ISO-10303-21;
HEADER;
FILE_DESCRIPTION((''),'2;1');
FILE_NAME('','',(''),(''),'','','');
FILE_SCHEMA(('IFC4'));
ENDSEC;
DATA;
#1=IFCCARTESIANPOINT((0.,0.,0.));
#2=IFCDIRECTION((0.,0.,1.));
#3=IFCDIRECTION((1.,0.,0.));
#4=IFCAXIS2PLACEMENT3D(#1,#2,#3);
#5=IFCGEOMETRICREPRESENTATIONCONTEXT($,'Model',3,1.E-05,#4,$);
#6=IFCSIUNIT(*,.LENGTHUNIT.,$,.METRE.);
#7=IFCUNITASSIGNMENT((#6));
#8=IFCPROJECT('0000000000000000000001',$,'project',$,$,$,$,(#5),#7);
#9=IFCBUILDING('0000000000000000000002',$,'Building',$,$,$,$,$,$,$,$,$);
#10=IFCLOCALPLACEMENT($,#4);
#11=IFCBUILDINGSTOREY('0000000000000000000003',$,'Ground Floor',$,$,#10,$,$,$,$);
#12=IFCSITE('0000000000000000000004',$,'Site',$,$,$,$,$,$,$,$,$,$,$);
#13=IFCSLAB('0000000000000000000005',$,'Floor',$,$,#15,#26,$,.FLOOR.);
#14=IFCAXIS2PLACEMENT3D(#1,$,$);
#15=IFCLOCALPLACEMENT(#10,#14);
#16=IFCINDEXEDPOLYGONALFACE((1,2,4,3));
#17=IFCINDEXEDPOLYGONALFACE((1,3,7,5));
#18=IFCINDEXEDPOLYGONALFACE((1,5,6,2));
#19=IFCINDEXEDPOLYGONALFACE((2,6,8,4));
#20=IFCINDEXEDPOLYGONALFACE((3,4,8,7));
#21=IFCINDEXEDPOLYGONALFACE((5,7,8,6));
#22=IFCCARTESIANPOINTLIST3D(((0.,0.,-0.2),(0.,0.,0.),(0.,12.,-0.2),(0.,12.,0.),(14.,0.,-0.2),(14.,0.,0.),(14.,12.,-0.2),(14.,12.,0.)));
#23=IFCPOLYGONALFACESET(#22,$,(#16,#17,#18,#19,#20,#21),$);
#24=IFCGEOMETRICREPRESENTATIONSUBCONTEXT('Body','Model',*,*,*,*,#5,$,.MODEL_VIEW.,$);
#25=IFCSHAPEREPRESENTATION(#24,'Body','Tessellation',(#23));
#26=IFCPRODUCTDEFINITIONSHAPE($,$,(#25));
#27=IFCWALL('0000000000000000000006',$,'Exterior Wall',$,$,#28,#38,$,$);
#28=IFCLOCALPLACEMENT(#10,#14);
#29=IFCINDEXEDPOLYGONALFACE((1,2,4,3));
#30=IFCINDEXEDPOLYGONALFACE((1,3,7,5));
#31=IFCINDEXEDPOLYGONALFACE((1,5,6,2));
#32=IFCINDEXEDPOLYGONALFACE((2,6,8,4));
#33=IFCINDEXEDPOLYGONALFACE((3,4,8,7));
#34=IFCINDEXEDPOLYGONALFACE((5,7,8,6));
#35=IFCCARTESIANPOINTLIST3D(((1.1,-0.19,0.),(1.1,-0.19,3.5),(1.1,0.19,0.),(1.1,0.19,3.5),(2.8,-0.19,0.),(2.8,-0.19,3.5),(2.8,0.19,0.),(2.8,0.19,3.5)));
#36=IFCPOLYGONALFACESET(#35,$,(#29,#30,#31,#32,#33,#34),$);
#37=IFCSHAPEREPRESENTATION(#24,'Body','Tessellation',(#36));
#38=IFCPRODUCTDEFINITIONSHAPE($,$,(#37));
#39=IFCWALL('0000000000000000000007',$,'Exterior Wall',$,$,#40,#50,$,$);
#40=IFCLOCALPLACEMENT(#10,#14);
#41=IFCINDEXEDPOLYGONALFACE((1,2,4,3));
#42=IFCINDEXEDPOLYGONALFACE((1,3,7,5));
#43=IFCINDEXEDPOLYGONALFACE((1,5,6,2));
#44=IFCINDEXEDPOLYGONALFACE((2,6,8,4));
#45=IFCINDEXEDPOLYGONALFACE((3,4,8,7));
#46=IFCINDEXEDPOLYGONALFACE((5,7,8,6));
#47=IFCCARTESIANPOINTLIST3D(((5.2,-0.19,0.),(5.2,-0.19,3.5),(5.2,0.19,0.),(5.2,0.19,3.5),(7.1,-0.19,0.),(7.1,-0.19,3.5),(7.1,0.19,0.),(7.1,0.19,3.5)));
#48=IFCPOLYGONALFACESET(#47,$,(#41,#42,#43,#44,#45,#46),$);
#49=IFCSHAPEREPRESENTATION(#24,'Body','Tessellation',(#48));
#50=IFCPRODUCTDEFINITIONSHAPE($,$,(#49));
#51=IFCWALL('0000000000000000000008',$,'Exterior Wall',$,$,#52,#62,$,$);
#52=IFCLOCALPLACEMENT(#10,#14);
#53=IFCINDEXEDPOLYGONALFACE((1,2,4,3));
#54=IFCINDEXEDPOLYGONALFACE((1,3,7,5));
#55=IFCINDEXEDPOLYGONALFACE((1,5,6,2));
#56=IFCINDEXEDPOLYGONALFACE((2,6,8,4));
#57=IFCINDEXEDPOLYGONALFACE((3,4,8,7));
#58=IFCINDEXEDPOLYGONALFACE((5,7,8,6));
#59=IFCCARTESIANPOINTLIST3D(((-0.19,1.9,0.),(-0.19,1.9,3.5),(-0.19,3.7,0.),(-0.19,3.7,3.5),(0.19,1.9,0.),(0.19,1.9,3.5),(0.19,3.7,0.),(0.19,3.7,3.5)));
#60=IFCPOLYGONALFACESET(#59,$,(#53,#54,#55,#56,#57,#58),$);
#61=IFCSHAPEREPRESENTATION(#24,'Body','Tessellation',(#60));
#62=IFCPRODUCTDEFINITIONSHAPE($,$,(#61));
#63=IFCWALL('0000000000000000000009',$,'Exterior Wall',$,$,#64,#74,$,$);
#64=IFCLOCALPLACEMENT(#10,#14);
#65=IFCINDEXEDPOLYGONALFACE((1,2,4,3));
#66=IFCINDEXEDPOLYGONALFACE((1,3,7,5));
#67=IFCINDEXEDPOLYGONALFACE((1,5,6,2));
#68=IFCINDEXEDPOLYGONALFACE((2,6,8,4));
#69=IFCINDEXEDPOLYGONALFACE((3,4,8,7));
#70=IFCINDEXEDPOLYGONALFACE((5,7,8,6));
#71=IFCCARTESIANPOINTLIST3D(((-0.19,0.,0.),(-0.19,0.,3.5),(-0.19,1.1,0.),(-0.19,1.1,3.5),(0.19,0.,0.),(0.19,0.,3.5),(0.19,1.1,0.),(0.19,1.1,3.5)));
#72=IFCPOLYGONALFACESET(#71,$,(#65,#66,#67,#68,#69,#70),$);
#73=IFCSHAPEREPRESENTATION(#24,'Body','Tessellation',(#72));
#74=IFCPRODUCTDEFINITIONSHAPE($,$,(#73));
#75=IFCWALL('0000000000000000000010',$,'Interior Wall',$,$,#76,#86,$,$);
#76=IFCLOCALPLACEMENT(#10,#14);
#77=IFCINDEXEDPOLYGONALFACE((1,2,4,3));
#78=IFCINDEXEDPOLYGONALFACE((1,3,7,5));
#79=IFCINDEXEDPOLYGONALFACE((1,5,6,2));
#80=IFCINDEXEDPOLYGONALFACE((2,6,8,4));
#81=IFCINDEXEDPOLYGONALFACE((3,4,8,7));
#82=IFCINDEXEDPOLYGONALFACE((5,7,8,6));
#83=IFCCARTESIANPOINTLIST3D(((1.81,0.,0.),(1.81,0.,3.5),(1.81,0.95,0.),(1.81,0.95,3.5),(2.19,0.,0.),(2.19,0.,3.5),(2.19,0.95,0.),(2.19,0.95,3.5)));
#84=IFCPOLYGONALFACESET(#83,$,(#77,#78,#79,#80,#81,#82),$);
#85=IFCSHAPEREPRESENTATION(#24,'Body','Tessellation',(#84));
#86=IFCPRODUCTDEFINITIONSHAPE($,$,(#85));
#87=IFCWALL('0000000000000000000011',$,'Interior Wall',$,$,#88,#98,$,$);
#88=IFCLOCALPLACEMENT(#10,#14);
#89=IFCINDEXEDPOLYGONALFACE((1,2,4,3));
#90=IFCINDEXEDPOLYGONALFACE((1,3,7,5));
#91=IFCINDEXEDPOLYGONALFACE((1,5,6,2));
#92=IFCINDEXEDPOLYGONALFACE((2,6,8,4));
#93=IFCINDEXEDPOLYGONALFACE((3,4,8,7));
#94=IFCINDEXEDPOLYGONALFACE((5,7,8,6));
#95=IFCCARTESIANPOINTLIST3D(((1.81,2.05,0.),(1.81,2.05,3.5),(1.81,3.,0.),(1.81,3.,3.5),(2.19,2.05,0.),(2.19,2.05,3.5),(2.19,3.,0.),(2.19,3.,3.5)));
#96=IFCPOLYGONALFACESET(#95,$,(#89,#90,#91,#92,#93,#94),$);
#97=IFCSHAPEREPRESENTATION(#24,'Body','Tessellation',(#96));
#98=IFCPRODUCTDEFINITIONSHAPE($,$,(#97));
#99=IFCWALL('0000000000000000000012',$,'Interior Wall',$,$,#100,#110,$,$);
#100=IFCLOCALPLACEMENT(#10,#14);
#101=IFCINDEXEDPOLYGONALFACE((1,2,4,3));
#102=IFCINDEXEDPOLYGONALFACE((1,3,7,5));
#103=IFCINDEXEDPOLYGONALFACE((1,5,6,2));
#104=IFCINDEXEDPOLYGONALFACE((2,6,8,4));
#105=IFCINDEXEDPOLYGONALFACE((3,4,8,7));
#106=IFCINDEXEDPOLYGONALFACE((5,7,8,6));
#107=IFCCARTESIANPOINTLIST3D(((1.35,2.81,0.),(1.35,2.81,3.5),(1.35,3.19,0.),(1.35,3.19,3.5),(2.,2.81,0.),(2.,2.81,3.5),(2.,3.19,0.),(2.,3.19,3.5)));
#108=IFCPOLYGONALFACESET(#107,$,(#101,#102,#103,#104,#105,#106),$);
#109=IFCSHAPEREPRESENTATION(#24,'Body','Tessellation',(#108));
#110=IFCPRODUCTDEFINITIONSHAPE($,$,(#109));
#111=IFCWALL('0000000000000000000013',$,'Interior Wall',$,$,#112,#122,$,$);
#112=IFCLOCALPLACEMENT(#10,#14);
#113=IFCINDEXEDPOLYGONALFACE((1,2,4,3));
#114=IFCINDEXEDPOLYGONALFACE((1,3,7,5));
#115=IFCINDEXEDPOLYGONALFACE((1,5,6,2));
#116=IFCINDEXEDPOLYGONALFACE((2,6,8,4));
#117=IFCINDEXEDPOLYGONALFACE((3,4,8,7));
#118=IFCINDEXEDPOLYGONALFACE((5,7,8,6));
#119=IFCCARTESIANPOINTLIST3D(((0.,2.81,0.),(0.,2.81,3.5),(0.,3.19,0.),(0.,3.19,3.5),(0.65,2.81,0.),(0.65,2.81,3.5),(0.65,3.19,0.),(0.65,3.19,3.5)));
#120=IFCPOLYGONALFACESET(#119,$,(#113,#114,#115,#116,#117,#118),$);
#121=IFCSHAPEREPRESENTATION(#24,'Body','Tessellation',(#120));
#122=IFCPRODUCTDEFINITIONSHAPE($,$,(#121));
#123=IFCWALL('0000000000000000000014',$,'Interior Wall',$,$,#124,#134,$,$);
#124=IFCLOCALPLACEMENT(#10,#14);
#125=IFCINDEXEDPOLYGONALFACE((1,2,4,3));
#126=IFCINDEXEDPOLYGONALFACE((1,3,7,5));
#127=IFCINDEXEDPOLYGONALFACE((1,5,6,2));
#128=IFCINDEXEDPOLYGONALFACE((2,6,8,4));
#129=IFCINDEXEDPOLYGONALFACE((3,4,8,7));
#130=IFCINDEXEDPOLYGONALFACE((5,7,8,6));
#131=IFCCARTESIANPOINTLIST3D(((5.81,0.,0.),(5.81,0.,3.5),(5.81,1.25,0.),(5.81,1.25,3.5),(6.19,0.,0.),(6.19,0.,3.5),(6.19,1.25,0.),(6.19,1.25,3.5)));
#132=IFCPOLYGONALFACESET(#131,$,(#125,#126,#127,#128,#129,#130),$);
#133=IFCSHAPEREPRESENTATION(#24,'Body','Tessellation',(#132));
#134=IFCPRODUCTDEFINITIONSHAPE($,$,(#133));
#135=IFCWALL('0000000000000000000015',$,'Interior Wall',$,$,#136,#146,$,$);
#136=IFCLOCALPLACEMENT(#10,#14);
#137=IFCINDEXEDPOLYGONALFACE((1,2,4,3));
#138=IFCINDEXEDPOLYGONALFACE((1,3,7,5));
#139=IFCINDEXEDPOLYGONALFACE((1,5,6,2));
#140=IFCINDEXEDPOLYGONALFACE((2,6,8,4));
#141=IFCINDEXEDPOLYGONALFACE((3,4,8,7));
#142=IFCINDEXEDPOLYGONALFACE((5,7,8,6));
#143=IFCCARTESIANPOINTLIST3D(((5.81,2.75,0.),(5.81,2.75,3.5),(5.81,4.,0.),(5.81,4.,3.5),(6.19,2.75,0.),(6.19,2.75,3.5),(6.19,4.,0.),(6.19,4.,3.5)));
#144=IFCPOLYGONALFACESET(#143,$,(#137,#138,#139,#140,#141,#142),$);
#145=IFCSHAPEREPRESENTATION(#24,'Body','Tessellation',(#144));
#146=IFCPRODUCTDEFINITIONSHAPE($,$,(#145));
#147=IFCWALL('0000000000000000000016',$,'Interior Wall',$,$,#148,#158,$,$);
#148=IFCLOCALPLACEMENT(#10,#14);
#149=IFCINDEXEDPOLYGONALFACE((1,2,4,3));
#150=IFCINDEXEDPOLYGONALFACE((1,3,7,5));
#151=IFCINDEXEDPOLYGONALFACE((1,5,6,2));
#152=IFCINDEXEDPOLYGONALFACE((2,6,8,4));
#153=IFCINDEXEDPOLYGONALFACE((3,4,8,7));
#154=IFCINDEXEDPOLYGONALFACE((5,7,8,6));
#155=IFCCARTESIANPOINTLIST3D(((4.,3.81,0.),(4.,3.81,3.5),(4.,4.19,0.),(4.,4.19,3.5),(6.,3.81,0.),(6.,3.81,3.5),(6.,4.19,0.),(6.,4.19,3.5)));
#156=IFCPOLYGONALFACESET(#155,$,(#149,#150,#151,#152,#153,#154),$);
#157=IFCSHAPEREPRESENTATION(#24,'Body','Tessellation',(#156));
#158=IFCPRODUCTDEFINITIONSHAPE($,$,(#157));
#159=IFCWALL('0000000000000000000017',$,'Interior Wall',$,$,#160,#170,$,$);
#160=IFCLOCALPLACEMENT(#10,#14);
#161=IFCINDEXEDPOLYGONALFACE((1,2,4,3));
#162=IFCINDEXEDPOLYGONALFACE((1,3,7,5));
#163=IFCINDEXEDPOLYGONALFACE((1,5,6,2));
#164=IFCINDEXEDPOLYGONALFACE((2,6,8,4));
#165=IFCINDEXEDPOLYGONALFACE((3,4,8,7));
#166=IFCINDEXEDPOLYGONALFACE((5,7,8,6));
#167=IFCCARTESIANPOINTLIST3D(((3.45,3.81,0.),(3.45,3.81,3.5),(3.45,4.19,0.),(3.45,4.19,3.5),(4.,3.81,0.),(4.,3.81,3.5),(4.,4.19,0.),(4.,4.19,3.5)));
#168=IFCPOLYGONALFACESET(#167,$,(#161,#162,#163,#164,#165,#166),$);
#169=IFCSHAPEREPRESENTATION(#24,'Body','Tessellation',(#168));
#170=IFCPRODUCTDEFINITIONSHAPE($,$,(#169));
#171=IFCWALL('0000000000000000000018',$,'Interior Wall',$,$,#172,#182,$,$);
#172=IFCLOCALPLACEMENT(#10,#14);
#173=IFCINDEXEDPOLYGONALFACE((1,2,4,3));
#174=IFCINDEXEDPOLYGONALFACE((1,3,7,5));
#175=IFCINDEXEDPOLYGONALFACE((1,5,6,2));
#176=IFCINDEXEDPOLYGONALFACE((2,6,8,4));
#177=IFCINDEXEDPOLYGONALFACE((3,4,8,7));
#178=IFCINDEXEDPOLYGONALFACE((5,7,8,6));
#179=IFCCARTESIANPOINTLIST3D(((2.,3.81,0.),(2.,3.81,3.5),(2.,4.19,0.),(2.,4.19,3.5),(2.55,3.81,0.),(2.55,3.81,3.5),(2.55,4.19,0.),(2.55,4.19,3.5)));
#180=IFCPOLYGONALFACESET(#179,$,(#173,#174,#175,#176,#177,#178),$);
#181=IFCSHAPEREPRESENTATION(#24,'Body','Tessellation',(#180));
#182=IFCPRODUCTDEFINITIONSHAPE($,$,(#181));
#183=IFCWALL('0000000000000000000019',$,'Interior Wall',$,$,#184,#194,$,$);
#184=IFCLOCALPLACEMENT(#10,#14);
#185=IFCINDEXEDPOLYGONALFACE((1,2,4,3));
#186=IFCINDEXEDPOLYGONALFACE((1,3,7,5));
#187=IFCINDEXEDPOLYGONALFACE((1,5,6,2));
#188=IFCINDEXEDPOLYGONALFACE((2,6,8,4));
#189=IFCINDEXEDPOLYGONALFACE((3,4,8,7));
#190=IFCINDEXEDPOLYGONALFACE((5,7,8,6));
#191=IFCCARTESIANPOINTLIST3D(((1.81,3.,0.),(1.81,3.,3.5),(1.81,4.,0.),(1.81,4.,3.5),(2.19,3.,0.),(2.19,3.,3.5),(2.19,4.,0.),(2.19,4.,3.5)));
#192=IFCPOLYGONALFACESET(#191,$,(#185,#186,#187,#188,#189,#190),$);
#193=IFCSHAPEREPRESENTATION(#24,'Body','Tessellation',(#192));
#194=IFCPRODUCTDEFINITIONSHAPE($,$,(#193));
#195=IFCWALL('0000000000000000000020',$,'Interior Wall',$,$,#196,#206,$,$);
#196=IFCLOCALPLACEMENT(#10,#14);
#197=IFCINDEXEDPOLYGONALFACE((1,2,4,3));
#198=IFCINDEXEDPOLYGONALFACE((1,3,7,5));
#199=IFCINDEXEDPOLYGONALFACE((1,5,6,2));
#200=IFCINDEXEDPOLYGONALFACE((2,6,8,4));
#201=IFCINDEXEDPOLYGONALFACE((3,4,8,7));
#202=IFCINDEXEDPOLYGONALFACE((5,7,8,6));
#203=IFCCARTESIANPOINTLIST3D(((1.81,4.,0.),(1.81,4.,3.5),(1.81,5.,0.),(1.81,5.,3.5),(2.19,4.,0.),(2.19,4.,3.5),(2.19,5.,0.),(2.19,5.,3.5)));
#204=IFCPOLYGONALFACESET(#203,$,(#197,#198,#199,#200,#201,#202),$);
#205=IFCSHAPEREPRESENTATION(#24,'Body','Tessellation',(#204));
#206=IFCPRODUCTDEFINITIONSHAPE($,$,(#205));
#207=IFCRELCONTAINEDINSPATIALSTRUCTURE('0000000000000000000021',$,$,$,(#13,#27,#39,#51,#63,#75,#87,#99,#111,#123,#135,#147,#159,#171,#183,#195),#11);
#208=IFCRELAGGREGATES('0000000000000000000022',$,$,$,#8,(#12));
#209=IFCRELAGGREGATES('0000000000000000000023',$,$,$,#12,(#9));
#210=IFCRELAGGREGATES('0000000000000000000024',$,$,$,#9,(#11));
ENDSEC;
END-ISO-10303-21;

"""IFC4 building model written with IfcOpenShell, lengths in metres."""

from ifc_helpers import new_model, si_unit, frame, origin_with_axes, place, context, subcontext, project, spatial, indexed_curve, outline, extrude, element, save


model = new_model("IFC4")

# Units and contexts
model_context = context("Model", 3, precision=1e-05, world=origin_with_axes())
body_context = subcontext(model_context, "Body", "Model", "MODEL_VIEW")
ifc_project = project(units=[si_unit("LENGTHUNIT", "METRE")], contexts=[model_context])

# Site, building, storey
site = spatial("IfcSite", under=ifc_project, Name="Site")
building = spatial("IfcBuilding", under=site, Name="Building")
storey_placement = place(None, origin_with_axes())
storey = spatial("IfcBuildingStorey", under=building, at=storey_placement, Name="Ground Floor")

# Slab
slab_placement = place(storey_placement, frame((0.0, 0.0, -0.2), z_axis=(0.0, 0.0, 1.0), x_axis=(1.0, 0.0, 0.0)))
element("IfcSlab", 1, at=slab_placement, inside=storey, Name="Floor", PredefinedType="FLOOR", context=body_context, shape_type="SweptSolid", body=[
    extrude(outline(indexed_curve([(0.0, 0.0), (14.0, 0.0), (14.0, 12.0), (0.0, 12.0)])), None, (0.0, 0.0, 1.0), 0.2),
])

# Walls
wall_1_placement = place(storey_placement, frame((1.1, 0.0, 0.0), z_axis=(0.0, 0.0, 1.0), x_axis=(1.0, 0.0, 0.0)))
element("IfcWall", 2, at=wall_1_placement, inside=storey, Name="Exterior Wall", context=body_context, shape_type="SweptSolid", body=[
    extrude(outline(indexed_curve([(0.0, 0.0), (0.0, 0.38), (1.7, 0.38), (1.7, 0.0), (0.0, 0.0)], self_intersect=False)), frame((0.0, -0.19, 0.0), z_axis=(0.0, 0.0, 1.0), x_axis=(1.0, 0.0, 0.0)), (0.0, 0.0, 1.0), 3.5),
])
wall_2_placement = place(storey_placement, frame((5.2, 0.0, 0.0), z_axis=(0.0, 0.0, 1.0), x_axis=(1.0, 0.0, 0.0)))
element("IfcWall", 3, at=wall_2_placement, inside=storey, Name="Exterior Wall", context=body_context, shape_type="SweptSolid", body=[
    extrude(outline(indexed_curve([(0.0, 0.0), (0.0, 0.38), (1.9, 0.38), (1.9, 0.0), (0.0, 0.0)], self_intersect=False)), frame((0.0, -0.19, 0.0), z_axis=(0.0, 0.0, 1.0), x_axis=(1.0, 0.0, 0.0)), (0.0, 0.0, 1.0), 3.5),
])
wall_3_placement = place(storey_placement, frame((0.0, 3.7, 0.0), z_axis=(0.0, 0.0, 1.0), x_axis=(0.0, -1.0, 0.0)))
element("IfcWall", 4, at=wall_3_placement, inside=storey, Name="Exterior Wall", context=body_context, shape_type="SweptSolid", body=[
    extrude(outline(indexed_curve([(0.0, 0.0), (0.0, 0.38), (1.8, 0.38), (1.8, 0.0), (0.0, 0.0)], self_intersect=False)), frame((0.0, -0.19, 0.0), z_axis=(0.0, 0.0, 1.0), x_axis=(1.0, 0.0, 0.0)), (0.0, 0.0, 1.0), 3.5),
])
wall_4_placement = place(storey_placement, frame((0.0, 1.1, 0.0), z_axis=(0.0, 0.0, 1.0), x_axis=(0.0, -1.0, 0.0)))
element("IfcWall", 5, at=wall_4_placement, inside=storey, Name="Exterior Wall", context=body_context, shape_type="SweptSolid", body=[
    extrude(outline(indexed_curve([(0.0, 0.0), (0.0, 0.38), (1.1, 0.38), (1.1, 0.0), (0.0, 0.0)], self_intersect=False)), frame((0.0, -0.19, 0.0), z_axis=(0.0, 0.0, 1.0), x_axis=(1.0, 0.0, 0.0)), (0.0, 0.0, 1.0), 3.5),
])
wall_5_placement = place(storey_placement, frame((2.0, 0.0, 0.0), z_axis=(0.0, 0.0, 1.0), x_axis=(0.0, 1.0, 0.0)))
element("IfcWall", 6, at=wall_5_placement, inside=storey, Name="Interior Wall", context=body_context, shape_type="SweptSolid", body=[
    extrude(outline(indexed_curve([(0.0, 0.0), (0.0, 0.38), (0.95, 0.38), (0.95, 0.0), (0.0, 0.0)], self_intersect=False)), frame((0.0, -0.19, 0.0), z_axis=(0.0, 0.0, 1.0), x_axis=(1.0, 0.0, 0.0)), (0.0, 0.0, 1.0), 3.5),
])
wall_6_placement = place(storey_placement, frame((2.0, 2.05, 0.0), z_axis=(0.0, 0.0, 1.0), x_axis=(0.0, 1.0, 0.0)))
element("IfcWall", 7, at=wall_6_placement, inside=storey, Name="Interior Wall", context=body_context, shape_type="SweptSolid", body=[
    extrude(outline(indexed_curve([(0.0, 0.0), (0.0, 0.38), (0.95, 0.38), (0.95, 0.0), (0.0, 0.0)], self_intersect=False)), frame((0.0, -0.19, 0.0), z_axis=(0.0, 0.0, 1.0), x_axis=(1.0, 0.0, 0.0)), (0.0, 0.0, 1.0), 3.5),
])
for number, where, z_axis, x_axis, name in (
    (8, (2.0, 3.0, 0.0), (0.0, 0.0, 1.0), (-1.0, 0.0, 0.0), "Interior Wall"),
    (9, (0.65, 3.0, 0.0), (0.0, 0.0, 1.0), (-1.0, 0.0, 0.0), "Interior Wall"),
):
    element("IfcWall", number, at=place(storey_placement, frame(where, z_axis=z_axis, x_axis=x_axis)), inside=storey, Name=name, context=body_context, shape_type="SweptSolid", body=[
        extrude(outline(indexed_curve([(0.0, 0.0), (0.0, 0.38), (0.65, 0.38), (0.65, 0.0), (0.0, 0.0)], self_intersect=False)), frame((0.0, -0.19, 0.0), z_axis=(0.0, 0.0, 1.0), x_axis=(1.0, 0.0, 0.0)), (0.0, 0.0, 1.0), 3.5),
    ])
for number, where, z_axis, x_axis, name in (
    (10, (6.0, 0.0, 0.0), (0.0, 0.0, 1.0), (0.0, 1.0, 0.0), "Interior Wall"),
    (11, (6.0, 2.75, 0.0), (0.0, 0.0, 1.0), (0.0, 1.0, 0.0), "Interior Wall"),
):
    element("IfcWall", number, at=place(storey_placement, frame(where, z_axis=z_axis, x_axis=x_axis)), inside=storey, Name=name, context=body_context, shape_type="SweptSolid", body=[
        extrude(outline(indexed_curve([(0.0, 0.0), (0.0, 0.38), (1.25, 0.38), (1.25, 0.0), (0.0, 0.0)], self_intersect=False)), frame((0.0, -0.19, 0.0), z_axis=(0.0, 0.0, 1.0), x_axis=(1.0, 0.0, 0.0)), (0.0, 0.0, 1.0), 3.5),
    ])
wall_7_placement = place(storey_placement, frame((6.0, 4.0, 0.0), z_axis=(0.0, 0.0, 1.0), x_axis=(-1.0, 0.0, 0.0)))
element("IfcWall", 12, at=wall_7_placement, inside=storey, Name="Interior Wall", context=body_context, shape_type="SweptSolid", body=[
    extrude(outline(indexed_curve([(0.0, 0.0), (0.0, 0.38), (2.0, 0.38), (2.0, 0.0), (0.0, 0.0)], self_intersect=False)), frame((0.0, -0.19, 0.0), z_axis=(0.0, 0.0, 1.0), x_axis=(1.0, 0.0, 0.0)), (0.0, 0.0, 1.0), 3.5),
])
for number, where, z_axis, x_axis, name in (
    (13, (4.0, 4.0, 0.0), (0.0, 0.0, 1.0), (-1.0, 0.0, 0.0), "Interior Wall"),
    (14, (2.55, 4.0, 0.0), (0.0, 0.0, 1.0), (-1.0, 0.0, 0.0), "Interior Wall"),
):
    element("IfcWall", number, at=place(storey_placement, frame(where, z_axis=z_axis, x_axis=x_axis)), inside=storey, Name=name, context=body_context, shape_type="SweptSolid", body=[
        extrude(outline(indexed_curve([(0.0, 0.0), (0.0, 0.38), (0.55, 0.38), (0.55, 0.0), (0.0, 0.0)], self_intersect=False)), frame((0.0, -0.19, 0.0), z_axis=(0.0, 0.0, 1.0), x_axis=(1.0, 0.0, 0.0)), (0.0, 0.0, 1.0), 3.5),
    ])
for number, where, z_axis, x_axis, name in (
    (15, (2.0, 4.0, 0.0), (0.0, 0.0, 1.0), (0.0, -1.0, 0.0), "Interior Wall"),
    (16, (2.0, 4.0, 0.0), (0.0, 0.0, 1.0), (0.0, 1.0, 0.0), "Interior Wall"),
):
    element("IfcWall", number, at=place(storey_placement, frame(where, z_axis=z_axis, x_axis=x_axis)), inside=storey, Name=name, context=body_context, shape_type="SweptSolid", body=[
        extrude(outline(indexed_curve([(0.0, 0.0), (0.0, 0.38), (1.0, 0.38), (1.0, 0.0), (0.0, 0.0)], self_intersect=False)), frame((0.0, -0.19, 0.0), z_axis=(0.0, 0.0, 1.0), x_axis=(1.0, 0.0, 0.0)), (0.0, 0.0, 1.0), 3.5),
    ])

save(model, "model.ifc")
